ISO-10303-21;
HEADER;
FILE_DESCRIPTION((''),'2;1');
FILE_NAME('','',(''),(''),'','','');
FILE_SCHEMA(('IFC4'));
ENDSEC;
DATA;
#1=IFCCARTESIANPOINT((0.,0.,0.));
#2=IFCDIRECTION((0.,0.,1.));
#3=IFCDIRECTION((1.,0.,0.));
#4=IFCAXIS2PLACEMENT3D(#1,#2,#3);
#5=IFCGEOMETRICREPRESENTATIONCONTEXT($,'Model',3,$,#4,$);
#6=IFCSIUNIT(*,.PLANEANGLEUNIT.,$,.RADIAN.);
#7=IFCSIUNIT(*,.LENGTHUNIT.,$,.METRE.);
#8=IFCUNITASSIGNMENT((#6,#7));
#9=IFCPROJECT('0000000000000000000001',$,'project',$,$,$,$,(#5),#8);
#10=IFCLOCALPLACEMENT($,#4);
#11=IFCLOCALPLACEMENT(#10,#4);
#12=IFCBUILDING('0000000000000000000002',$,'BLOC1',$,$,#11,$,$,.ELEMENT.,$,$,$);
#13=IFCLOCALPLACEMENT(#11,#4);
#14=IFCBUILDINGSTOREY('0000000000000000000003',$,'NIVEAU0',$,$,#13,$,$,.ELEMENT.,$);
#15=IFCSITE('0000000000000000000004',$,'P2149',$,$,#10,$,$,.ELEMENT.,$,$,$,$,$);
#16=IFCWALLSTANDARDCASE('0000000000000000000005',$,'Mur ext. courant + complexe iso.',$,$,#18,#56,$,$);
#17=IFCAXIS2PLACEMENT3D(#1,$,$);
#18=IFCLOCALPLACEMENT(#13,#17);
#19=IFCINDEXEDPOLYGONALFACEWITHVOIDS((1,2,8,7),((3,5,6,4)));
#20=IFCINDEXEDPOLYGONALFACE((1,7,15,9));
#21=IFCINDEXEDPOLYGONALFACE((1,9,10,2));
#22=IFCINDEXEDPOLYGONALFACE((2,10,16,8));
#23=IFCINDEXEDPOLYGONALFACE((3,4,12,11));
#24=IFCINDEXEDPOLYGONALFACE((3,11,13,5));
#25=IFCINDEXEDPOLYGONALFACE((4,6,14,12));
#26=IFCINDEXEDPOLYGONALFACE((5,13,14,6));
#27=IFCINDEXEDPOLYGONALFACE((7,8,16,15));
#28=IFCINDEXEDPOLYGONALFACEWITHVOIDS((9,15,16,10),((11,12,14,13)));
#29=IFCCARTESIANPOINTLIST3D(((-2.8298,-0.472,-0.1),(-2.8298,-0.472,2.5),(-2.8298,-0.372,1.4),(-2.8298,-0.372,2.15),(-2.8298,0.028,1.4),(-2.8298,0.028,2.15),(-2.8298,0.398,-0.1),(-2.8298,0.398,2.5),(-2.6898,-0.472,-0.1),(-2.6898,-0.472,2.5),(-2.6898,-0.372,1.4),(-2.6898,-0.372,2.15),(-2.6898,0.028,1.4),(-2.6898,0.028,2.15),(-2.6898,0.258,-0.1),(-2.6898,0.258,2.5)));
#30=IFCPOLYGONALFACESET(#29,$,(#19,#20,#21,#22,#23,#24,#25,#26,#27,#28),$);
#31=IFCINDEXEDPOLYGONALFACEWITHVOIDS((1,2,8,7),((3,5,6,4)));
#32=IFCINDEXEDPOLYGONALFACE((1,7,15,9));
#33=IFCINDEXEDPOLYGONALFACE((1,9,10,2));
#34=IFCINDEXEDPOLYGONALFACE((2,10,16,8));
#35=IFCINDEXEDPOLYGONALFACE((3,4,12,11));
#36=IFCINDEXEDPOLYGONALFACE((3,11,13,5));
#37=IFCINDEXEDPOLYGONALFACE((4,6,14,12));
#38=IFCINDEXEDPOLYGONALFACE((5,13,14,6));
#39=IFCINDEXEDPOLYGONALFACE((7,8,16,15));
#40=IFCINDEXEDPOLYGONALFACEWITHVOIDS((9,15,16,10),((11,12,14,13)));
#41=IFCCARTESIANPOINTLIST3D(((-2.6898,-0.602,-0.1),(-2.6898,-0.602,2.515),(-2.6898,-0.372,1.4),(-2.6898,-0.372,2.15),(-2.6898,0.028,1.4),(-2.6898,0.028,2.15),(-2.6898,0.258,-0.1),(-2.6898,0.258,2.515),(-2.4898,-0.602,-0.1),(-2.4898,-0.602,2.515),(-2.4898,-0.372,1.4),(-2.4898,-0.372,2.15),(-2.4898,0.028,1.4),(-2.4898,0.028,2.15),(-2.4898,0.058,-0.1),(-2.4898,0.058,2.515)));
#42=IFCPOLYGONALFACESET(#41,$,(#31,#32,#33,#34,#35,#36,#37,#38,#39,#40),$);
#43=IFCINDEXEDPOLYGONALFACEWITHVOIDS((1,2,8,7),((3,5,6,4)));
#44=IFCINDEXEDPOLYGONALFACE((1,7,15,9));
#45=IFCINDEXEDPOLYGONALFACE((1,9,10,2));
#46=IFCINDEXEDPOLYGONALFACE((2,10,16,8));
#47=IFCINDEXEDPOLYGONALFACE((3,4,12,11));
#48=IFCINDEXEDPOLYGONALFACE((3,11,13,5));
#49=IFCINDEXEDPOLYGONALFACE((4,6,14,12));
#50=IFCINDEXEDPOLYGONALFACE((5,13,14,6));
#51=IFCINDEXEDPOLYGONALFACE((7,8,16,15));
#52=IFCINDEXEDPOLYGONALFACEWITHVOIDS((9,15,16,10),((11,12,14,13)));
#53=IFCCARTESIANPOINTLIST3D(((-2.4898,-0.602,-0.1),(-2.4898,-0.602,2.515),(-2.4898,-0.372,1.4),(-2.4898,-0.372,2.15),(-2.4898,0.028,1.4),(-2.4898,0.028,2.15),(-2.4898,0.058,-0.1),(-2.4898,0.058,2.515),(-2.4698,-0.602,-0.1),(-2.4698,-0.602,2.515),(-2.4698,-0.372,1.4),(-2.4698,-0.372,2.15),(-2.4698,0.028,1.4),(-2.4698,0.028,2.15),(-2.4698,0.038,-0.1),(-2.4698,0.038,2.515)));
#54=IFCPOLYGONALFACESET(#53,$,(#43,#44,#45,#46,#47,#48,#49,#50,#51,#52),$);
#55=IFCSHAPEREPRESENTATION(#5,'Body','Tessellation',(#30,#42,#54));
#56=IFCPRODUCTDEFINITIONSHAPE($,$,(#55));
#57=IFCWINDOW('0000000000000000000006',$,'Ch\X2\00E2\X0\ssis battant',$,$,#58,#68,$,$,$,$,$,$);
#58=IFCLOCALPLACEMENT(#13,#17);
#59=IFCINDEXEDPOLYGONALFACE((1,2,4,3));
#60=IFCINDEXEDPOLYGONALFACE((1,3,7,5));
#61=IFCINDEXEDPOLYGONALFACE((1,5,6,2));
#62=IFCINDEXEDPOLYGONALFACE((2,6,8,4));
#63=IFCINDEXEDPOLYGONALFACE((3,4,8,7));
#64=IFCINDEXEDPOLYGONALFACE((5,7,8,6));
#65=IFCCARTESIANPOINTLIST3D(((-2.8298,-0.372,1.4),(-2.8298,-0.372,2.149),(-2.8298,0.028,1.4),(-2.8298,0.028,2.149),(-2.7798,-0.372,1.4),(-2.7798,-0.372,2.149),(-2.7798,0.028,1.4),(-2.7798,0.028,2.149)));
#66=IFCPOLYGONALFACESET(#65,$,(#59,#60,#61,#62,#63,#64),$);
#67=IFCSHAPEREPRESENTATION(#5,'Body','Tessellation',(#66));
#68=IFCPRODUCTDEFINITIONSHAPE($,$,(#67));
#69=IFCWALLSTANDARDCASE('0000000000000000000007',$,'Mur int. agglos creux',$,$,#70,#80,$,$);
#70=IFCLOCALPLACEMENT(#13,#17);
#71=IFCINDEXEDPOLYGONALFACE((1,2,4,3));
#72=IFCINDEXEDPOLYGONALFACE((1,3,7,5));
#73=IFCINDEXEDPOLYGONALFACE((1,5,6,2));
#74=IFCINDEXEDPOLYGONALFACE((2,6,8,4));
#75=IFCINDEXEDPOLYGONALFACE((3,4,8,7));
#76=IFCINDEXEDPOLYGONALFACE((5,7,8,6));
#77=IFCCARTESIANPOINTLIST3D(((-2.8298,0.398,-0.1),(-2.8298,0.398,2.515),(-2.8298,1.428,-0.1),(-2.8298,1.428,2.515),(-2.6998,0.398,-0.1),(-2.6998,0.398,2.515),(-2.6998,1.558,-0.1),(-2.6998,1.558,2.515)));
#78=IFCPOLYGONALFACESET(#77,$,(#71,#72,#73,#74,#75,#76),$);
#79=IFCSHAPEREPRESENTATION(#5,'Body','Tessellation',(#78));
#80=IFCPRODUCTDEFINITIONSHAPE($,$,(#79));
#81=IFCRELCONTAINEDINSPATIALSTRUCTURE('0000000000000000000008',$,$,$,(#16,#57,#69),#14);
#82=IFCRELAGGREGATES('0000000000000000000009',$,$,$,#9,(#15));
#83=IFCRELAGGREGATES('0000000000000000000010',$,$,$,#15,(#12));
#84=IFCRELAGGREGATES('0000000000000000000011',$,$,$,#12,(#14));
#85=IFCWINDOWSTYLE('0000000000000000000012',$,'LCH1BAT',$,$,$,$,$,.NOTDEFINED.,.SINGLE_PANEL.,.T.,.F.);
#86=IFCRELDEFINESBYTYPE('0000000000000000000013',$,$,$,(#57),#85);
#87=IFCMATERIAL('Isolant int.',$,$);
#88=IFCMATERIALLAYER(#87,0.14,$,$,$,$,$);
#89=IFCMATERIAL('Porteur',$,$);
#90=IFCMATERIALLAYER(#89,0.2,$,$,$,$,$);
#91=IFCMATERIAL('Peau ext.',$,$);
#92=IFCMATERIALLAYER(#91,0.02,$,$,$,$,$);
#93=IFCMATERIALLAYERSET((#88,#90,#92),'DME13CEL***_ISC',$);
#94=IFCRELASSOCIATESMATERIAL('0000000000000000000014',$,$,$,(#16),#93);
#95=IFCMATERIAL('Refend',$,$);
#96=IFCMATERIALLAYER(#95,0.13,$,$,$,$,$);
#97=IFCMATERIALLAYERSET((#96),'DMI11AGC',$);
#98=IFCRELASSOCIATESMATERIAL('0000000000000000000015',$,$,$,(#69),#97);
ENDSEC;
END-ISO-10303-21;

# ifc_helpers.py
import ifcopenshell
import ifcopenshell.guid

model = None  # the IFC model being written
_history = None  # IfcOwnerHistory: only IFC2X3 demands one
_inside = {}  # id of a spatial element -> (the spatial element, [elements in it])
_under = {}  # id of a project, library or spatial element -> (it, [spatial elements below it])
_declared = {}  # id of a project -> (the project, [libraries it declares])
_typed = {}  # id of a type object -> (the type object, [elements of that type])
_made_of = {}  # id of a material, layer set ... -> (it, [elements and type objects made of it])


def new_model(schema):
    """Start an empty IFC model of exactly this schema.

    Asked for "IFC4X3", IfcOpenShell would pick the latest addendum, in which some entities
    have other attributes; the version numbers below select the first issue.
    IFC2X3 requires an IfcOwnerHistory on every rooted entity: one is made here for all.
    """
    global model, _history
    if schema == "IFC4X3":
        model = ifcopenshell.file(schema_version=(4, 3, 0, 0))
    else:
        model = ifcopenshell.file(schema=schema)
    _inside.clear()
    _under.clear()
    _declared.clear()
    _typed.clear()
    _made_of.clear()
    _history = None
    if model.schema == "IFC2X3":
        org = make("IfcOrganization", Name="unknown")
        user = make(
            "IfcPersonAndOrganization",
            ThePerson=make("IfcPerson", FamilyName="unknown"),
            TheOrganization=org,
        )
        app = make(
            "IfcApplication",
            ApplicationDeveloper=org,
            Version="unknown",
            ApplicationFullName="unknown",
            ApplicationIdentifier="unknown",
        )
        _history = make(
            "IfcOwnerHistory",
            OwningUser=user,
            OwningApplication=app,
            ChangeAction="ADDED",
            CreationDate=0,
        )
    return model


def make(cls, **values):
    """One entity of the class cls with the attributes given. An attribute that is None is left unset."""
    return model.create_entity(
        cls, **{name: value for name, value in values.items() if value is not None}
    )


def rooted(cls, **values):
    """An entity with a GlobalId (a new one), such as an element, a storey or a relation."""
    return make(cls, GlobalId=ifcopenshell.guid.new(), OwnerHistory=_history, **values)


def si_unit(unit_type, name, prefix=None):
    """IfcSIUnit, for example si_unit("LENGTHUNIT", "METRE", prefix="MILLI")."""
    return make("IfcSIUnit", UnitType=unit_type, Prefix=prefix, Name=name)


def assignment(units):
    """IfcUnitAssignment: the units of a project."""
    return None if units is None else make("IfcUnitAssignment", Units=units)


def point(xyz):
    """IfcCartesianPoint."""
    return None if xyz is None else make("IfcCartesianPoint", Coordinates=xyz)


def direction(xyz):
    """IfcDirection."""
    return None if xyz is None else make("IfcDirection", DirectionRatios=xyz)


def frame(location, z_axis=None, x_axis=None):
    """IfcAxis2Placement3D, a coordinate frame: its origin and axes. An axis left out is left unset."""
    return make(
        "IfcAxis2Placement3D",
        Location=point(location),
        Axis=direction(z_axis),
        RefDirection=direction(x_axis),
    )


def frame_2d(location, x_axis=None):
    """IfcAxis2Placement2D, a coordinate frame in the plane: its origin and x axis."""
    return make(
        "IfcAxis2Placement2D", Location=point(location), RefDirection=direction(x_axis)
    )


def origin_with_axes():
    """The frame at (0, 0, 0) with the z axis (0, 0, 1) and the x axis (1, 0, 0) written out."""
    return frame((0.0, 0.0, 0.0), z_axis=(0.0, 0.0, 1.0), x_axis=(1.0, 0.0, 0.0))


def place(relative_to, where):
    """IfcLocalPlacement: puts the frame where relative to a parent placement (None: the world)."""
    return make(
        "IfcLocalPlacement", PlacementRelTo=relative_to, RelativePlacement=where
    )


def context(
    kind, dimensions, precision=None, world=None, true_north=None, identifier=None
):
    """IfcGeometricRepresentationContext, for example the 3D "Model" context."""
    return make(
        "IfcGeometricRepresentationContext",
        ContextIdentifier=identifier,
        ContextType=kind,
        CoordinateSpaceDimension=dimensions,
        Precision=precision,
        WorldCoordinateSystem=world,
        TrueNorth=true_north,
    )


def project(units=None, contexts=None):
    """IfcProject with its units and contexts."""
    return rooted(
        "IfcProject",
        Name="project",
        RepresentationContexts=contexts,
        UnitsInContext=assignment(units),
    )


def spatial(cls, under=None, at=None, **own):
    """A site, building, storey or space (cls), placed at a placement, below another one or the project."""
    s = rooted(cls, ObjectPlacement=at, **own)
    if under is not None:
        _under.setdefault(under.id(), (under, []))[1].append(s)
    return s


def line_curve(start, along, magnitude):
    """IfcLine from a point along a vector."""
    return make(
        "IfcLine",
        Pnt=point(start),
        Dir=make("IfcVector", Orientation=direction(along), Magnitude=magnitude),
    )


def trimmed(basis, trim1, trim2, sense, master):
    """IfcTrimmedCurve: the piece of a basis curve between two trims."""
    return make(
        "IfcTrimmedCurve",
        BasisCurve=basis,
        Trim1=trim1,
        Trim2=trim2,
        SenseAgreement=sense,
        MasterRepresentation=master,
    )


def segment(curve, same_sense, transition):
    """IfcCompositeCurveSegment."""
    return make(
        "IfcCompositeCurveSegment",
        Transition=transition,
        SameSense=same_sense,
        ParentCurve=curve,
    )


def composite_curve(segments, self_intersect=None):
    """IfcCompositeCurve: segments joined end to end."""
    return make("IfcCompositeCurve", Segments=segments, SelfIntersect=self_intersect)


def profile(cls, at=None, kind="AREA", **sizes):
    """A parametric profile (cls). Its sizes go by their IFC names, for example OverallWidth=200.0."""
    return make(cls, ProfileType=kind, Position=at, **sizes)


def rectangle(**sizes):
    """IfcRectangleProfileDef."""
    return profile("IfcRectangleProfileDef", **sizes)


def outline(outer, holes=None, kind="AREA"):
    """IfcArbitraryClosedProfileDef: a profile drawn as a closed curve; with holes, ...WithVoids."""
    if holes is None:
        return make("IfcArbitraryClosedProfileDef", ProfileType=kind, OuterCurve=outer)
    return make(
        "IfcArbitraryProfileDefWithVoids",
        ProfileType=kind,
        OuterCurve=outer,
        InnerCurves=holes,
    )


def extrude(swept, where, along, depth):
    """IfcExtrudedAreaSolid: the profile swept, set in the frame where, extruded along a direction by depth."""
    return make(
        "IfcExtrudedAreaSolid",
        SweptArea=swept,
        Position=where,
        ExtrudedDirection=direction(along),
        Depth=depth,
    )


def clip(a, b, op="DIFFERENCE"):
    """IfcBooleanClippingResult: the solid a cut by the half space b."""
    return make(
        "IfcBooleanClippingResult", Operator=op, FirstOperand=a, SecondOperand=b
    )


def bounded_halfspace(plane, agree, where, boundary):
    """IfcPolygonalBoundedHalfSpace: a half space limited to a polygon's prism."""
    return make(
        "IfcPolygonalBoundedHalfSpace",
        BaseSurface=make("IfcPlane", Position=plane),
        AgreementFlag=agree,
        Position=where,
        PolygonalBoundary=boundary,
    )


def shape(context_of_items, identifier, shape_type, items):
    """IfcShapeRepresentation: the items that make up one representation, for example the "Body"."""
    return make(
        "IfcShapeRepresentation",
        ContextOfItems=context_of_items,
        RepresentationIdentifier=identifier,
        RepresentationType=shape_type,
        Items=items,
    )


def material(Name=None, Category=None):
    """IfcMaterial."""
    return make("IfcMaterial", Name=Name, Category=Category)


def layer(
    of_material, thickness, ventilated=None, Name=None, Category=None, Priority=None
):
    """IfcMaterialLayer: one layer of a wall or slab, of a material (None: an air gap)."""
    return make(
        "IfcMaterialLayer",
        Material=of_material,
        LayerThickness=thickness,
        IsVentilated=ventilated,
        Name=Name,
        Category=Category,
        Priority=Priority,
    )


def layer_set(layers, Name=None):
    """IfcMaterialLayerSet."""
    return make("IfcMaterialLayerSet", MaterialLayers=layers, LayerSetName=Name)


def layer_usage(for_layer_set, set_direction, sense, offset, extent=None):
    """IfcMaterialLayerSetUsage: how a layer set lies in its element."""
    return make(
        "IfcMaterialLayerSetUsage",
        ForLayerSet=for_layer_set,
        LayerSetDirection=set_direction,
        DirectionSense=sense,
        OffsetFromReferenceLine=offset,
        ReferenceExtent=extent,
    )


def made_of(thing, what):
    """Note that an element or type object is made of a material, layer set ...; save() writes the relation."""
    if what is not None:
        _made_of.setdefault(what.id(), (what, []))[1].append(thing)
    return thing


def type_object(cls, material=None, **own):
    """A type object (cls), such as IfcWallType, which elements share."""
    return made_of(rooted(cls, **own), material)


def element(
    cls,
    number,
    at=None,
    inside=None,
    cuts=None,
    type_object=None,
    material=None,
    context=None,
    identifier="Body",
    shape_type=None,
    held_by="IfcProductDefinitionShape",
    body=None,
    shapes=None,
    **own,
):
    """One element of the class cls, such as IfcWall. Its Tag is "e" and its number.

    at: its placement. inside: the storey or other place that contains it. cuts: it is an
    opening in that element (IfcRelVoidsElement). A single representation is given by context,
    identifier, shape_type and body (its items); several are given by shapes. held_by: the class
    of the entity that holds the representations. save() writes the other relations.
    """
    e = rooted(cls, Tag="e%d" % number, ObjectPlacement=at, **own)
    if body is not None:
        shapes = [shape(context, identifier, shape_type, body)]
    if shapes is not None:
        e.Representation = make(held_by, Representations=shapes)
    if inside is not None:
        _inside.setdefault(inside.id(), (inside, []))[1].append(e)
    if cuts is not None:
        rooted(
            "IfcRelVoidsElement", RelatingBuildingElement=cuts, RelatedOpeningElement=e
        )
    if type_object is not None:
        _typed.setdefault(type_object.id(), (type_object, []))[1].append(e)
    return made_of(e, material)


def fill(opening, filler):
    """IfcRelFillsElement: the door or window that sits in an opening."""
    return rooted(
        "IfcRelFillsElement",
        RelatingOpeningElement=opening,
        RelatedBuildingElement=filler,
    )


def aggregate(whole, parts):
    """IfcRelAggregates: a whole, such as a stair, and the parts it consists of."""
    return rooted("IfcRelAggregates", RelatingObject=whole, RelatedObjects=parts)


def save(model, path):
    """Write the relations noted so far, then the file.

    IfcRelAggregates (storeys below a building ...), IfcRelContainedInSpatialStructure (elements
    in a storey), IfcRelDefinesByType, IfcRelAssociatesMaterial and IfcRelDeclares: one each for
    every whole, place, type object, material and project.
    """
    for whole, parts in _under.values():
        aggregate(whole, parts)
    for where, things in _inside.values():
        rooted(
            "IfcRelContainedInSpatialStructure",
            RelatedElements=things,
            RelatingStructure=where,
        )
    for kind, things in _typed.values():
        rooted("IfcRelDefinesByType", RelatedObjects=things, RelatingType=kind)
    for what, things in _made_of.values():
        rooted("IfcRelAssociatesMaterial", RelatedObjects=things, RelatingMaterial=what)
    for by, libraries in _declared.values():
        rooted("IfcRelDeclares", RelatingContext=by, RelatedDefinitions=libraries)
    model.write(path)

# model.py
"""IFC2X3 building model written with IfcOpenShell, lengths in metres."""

from ifc_helpers import new_model, si_unit, point, frame, frame_2d, origin_with_axes, place, context, project, spatial, line_curve, trimmed, segment, composite_curve, rectangle, outline, extrude, clip, bounded_halfspace, material, layer, layer_set, layer_usage, type_object, element, fill, save


model = new_model("IFC2X3")

# Units and contexts
model_context = context("Model", 3, world=origin_with_axes())
ifc_project = project(units=[si_unit("PLANEANGLEUNIT", "RADIAN"), si_unit("LENGTHUNIT", "METRE")], contexts=[model_context])

# Site, building, storey
site_placement = place(None, origin_with_axes())
site = spatial("IfcSite", under=ifc_project, at=site_placement, Name="P2149", CompositionType="ELEMENT")
building_placement = place(site_placement, origin_with_axes())
building = spatial("IfcBuilding", under=site, at=building_placement, Name="BLOC1", CompositionType="ELEMENT")
storey_placement = place(building_placement, origin_with_axes())
storey = spatial("IfcBuildingStorey", under=building, at=storey_placement, Name="NIVEAU0", CompositionType="ELEMENT")

# Shared definitions
ifc_material_1 = material(Name="Isolant int.")
ifc_layer_1 = layer(ifc_material_1, 0.14)
ifc_material_2 = material(Name="Porteur")
ifc_layer_2 = layer(ifc_material_2, 0.2)
ifc_material_3 = material(Name="Peau ext.")
ifc_layer_3 = layer(ifc_material_3, 0.02)
ifc_layer_set_1 = layer_set([ifc_layer_1, ifc_layer_2, ifc_layer_3], Name="DME13CEL***_ISC")
ifc_layer_usage_1 = layer_usage(ifc_layer_set_1, "AXIS2", "POSITIVE", 0.0)

# Shared definitions
ifc_material_4 = material(Name="Refend")
ifc_layer_4 = layer(ifc_material_4, 0.13)
ifc_layer_set_2 = layer_set([ifc_layer_4], Name="DMI11AGC")
ifc_layer_usage_2 = layer_usage(ifc_layer_set_2, "AXIS2", "POSITIVE", 0.0)

# Wall, opening, window
wall_1_placement = place(storey_placement, frame((-2.8298, 0.398, -0.1), z_axis=(0.0, 0.0, 1.0), x_axis=(0.0, -1.0, 0.0)))
wall_1 = element("IfcWallStandardCase", 1, at=wall_1_placement, inside=storey, material=ifc_layer_usage_1, Name="Mur ext. courant + complexe iso.", context=model_context, shape_type="Clipping", body=[
    clip(extrude(outline(composite_curve([segment(trimmed(line_curve((0.0, 0.0), (1.0, 0.0), 0.87), [point((0.0, 0.0))], [point((0.87, 0.0))], True, "CARTESIAN"), True, "CONTINUOUS"), segment(trimmed(line_curve((0.87, 0.0), (0.0, 1.0), 0.14), [point((0.87, 0.0))], [point((0.87, 0.14))], True, "CARTESIAN"), True, "CONTINUOUS"), segment(trimmed(line_curve((0.87, 0.14), (-1.0, 0.0), 0.73), [point((0.87, 0.14))], [point((0.14, 0.14))], True, "CARTESIAN"), True, "CONTINUOUS"), segment(trimmed(line_curve((0.14, 0.14), (-0.707107, -0.707107), 0.19799), [point((0.14, 0.14))], [point((0.0, 0.0))], True, "CARTESIAN"), True, "CONTINUOUS")], self_intersect=False)), origin_with_axes(), (0.0, 0.0, 1.0), 2.615), bounded_halfspace(frame((0.0, 0.0, 2.6), z_axis=(0.0, 0.0, 1.0), x_axis=(0.0, 1.0, 0.0)), False, frame((0.0, 0.0, 2.6), z_axis=(0.0, 0.0, 1.0), x_axis=(1.0, 0.0, 0.0)), composite_curve([segment(trimmed(line_curve((0.0, 0.0), (1.0, 0.0), 0.87), [point((0.0, 0.0))], [point((0.87, 0.0))], True, "CARTESIAN"), True, "CONTINUOUS"), segment(trimmed(line_curve((0.87, 0.0), (0.0, 1.0), 0.14), [point((0.87, 0.0))], [point((0.87, 0.14))], True, "CARTESIAN"), True, "CONTINUOUS"), segment(trimmed(line_curve((0.87, 0.14), (-1.0, 0.0), 0.73), [point((0.87, 0.14))], [point((0.14, 0.14))], True, "CARTESIAN"), True, "CONTINUOUS"), segment(trimmed(line_curve((0.14, 0.14), (-0.707107, -0.707107), 0.19799), [point((0.14, 0.14))], [point((0.0, 0.0))], True, "CARTESIAN"), True, "CONTINUOUS")], self_intersect=False))),
    extrude(outline(composite_curve([segment(trimmed(line_curve((0.14, 0.14), (1.0, 0.0), 0.86), [point((0.14, 0.14))], [point((1.0, 0.14))], True, "CARTESIAN"), True, "CONTINUOUS"), segment(trimmed(line_curve((1.0, 0.14), (0.0, 1.0), 0.2), [point((1.0, 0.14))], [point((1.0, 0.34))], True, "CARTESIAN"), True, "CONTINUOUS"), segment(trimmed(line_curve((1.0, 0.34), (-1.0, 0.0), 0.66), [point((1.0, 0.34))], [point((0.34, 0.34))], True, "CARTESIAN"), True, "CONTINUOUS"), segment(trimmed(line_curve((0.34, 0.34), (-0.707107, -0.707107), 0.282843), [point((0.34, 0.34))], [point((0.14, 0.14))], True, "CARTESIAN"), True, "CONTINUOUS")], self_intersect=False)), origin_with_axes(), (0.0, 0.0, 1.0), 2.615),
    extrude(outline(composite_curve([segment(trimmed(line_curve((0.34, 0.34), (1.0, 0.0), 0.66), [point((0.34, 0.34))], [point((1.0, 0.34))], True, "CARTESIAN"), True, "CONTINUOUS"), segment(trimmed(line_curve((1.0, 0.34), (0.0, 1.0), 0.02), [point((1.0, 0.34))], [point((1.0, 0.36))], True, "CARTESIAN"), True, "CONTINUOUS"), segment(trimmed(line_curve((1.0, 0.36), (-1.0, 0.0), 0.64), [point((1.0, 0.36))], [point((0.36, 0.36))], True, "CARTESIAN"), True, "CONTINUOUS"), segment(trimmed(line_curve((0.36, 0.36), (-0.707107, -0.707107), 0.028284), [point((0.36, 0.36))], [point((0.34, 0.34))], True, "CARTESIAN"), True, "CONTINUOUS")], self_intersect=False)), origin_with_axes(), (0.0, 0.0, 1.0), 2.615),
])
opening_1_placement = place(wall_1_placement, frame((0.37, 0.0, 1.5), z_axis=(0.0, -1.0, 0.0), x_axis=(1.0, 0.0, 0.0)))
opening_1 = element("IfcOpeningElement", 2, at=opening_1_placement, cuts=wall_1, context=model_context, shape_type="SweptSolid", body=[
    extrude(rectangle(XDim=0.4, YDim=0.75, at=frame_2d((0.2, 0.375), x_axis=(1.0, 0.0))), origin_with_axes(), (0.0, 0.0, -1.0), 0.36),
])
window_style_1 = type_object("IfcWindowStyle", Name="LCH1BAT", ConstructionType="NOTDEFINED", OperationType="SINGLE_PANEL", ParameterTakesPrecedence=True, Sizeable=False)
window_1_placement = place(opening_1_placement, origin_with_axes())
window_1 = element("IfcWindow", 3, at=window_1_placement, inside=storey, type_object=window_style_1, Name="Châssis battant", context=model_context, shape_type="SweptSolid", body=[
    extrude(rectangle(XDim=0.4, YDim=0.749, at=frame_2d((0.2, 0.3745), x_axis=(1.0, 0.0))), origin_with_axes(), (0.0, 0.0, -1.0), 0.05),
])
fill(opening_1, window_1)

# Wall
wall_2_placement = place(storey_placement, frame((-2.6998, 0.398, -0.1), z_axis=(0.0, 0.0, 1.0), x_axis=(0.0, 1.0, 0.0)))
element("IfcWallStandardCase", 4, at=wall_2_placement, inside=storey, material=ifc_layer_usage_2, Name="Mur int. agglos creux", context=model_context, shape_type="SweptSolid", body=[
    extrude(outline(composite_curve([segment(trimmed(line_curve((0.0, 0.0), (1.0, 0.0), 1.16), [point((0.0, 0.0))], [point((1.16, 0.0))], True, "CARTESIAN"), True, "CONTINUOUS"), segment(trimmed(line_curve((1.16, 0.0), (-0.707107, 0.707107), 0.183848), [point((1.16, 0.0))], [point((1.03, 0.13))], True, "CARTESIAN"), True, "CONTINUOUS"), segment(trimmed(line_curve((1.03, 0.13), (-1.0, 0.0), 1.03), [point((1.03, 0.13))], [point((0.0, 0.13))], True, "CARTESIAN"), True, "CONTINUOUS"), segment(trimmed(line_curve((0.0, 0.13), (0.0, -1.0), 0.13), [point((0.0, 0.13))], [point((0.0, 0.0))], True, "CARTESIAN"), True, "CONTINUOUS")], self_intersect=False)), origin_with_axes(), (0.0, 0.0, 1.0), 2.615),
])

save(model, "model.ifc")
